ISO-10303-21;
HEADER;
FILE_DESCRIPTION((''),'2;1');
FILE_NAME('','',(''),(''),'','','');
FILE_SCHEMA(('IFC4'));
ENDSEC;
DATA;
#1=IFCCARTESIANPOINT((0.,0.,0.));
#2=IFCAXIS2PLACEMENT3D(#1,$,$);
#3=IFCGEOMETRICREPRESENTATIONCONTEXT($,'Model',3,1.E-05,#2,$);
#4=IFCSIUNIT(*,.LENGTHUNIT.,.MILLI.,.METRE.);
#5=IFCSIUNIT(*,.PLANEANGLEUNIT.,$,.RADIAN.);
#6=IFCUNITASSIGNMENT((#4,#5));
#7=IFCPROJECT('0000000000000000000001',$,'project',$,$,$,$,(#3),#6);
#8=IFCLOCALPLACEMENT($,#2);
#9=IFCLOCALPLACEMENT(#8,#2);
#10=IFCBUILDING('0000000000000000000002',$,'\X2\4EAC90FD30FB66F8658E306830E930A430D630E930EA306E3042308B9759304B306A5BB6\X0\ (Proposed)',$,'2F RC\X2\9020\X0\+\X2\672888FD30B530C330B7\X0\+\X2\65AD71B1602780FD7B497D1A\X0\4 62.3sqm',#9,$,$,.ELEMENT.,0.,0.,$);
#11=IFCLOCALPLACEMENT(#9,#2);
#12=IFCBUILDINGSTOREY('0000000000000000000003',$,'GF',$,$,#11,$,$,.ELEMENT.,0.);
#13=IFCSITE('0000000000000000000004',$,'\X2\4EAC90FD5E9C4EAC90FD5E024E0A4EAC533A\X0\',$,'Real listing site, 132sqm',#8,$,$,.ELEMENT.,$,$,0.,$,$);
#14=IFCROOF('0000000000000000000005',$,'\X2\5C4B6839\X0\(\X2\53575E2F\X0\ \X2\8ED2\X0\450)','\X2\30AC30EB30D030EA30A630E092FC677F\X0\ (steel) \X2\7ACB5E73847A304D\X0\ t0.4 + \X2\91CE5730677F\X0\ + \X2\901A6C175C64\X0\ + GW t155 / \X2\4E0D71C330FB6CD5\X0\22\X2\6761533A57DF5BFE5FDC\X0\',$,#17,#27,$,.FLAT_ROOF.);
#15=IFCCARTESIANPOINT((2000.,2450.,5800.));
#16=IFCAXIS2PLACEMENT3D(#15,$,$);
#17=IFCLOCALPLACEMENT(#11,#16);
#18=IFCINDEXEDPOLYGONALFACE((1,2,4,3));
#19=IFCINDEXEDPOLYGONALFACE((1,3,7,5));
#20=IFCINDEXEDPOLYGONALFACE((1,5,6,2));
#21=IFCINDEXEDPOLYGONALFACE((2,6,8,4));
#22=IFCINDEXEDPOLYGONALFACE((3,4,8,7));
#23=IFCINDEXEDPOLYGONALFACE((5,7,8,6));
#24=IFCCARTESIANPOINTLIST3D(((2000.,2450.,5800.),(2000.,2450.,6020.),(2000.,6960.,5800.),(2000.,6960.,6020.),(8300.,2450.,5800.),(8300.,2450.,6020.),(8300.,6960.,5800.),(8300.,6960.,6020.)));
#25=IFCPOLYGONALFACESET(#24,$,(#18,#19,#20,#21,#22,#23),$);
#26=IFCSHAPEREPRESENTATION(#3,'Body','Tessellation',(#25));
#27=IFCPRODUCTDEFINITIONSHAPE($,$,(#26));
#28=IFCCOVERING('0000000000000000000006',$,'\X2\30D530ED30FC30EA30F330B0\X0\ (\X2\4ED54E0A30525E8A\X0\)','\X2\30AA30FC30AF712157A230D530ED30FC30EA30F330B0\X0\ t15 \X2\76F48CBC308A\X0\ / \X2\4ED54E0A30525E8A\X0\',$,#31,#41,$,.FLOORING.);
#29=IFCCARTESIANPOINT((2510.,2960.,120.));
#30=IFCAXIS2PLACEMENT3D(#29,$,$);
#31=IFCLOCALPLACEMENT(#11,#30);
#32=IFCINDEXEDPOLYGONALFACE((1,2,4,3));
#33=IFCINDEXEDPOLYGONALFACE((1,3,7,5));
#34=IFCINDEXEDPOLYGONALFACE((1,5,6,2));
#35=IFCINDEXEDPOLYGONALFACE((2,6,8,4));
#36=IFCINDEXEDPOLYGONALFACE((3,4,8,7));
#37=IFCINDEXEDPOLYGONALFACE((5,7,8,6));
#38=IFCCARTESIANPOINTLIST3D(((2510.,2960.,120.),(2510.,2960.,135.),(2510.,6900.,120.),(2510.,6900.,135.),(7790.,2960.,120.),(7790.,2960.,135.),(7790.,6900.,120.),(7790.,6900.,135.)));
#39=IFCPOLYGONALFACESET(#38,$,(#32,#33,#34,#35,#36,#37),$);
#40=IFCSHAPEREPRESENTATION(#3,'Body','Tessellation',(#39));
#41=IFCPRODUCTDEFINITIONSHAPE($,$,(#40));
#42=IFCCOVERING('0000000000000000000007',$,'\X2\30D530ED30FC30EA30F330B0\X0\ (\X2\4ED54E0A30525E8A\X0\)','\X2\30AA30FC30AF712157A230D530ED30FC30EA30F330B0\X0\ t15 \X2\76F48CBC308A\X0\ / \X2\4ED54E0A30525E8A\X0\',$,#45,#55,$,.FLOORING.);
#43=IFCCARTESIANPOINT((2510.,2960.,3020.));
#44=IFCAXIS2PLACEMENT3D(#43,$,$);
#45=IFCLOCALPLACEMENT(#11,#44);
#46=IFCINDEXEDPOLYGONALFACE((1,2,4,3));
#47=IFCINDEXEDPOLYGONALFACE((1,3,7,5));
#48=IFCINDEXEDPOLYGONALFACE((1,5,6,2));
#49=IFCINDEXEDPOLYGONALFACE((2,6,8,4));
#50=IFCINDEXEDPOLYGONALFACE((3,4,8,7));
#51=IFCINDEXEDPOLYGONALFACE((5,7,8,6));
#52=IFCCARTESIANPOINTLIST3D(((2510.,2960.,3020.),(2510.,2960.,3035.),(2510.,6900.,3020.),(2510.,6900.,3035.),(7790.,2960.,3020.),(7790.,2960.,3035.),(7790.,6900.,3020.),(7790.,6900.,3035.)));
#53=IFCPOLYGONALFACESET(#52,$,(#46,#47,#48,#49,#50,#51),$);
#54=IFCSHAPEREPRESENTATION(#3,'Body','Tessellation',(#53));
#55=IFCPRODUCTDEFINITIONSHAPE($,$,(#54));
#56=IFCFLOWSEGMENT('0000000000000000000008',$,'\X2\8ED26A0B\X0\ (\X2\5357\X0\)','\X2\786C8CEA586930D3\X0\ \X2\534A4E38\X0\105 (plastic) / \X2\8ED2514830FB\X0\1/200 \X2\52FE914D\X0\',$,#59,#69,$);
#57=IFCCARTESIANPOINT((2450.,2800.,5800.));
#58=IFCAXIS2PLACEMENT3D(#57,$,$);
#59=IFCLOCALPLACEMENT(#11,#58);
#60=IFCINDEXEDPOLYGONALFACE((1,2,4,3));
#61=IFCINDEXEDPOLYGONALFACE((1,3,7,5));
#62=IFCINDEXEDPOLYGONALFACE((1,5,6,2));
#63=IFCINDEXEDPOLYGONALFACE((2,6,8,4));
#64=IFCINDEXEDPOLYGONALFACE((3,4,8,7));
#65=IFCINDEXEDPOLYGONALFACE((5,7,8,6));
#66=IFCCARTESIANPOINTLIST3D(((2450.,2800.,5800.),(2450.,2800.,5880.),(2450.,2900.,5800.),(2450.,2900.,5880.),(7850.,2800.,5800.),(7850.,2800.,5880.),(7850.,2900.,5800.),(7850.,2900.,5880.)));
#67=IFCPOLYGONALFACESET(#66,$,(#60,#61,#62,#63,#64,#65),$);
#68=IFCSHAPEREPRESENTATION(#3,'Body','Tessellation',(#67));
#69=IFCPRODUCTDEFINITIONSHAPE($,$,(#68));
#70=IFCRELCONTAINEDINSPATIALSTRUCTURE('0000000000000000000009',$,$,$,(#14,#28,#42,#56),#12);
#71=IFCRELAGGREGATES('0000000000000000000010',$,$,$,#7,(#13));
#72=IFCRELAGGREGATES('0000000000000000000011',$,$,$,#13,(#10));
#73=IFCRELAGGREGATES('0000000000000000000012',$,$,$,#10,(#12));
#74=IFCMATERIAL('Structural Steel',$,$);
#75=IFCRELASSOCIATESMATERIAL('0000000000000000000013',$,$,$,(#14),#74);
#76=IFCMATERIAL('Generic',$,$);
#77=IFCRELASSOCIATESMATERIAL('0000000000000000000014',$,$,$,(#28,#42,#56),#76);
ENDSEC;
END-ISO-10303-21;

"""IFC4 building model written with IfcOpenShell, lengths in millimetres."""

from ifc_helpers import new_model, si_unit, frame, frame_2d, origin, place, context, project, spatial, rectangle, extrude, material, element, save


model = new_model("IFC4")

# Units and contexts
model_context = context("Model", 3, precision=1e-05, world=origin())
ifc_project = project(units=[si_unit("LENGTHUNIT", "METRE", prefix="MILLI"), si_unit("PLANEANGLEUNIT", "RADIAN")], contexts=[model_context])

# Site, building, storey
site_placement = place(None, origin())
site = spatial("IfcSite", under=ifc_project, at=site_placement, Name="京都府京都市上京区", ObjectType="Real listing site, 132sqm", CompositionType="ELEMENT", RefElevation=0.0)
building_placement = place(site_placement, origin())
building = spatial("IfcBuilding", under=site, at=building_placement, Name="京都・書斎とライブラリのある静かな家 (Proposed)", ObjectType="2F RC造+木製サッシ+断熱性能等級4 62.3sqm", CompositionType="ELEMENT", ElevationOfRefHeight=0.0, ElevationOfTerrain=0.0)
storey_placement = place(building_placement, origin())
storey = spatial("IfcBuildingStorey", under=building, at=storey_placement, Name="GF", CompositionType="ELEMENT", Elevation=0.0)

# Roof
ifc_material_1 = material(Name="Structural Steel")
for number, where, name in (
    (1, (2000.0, 2450.0, 5800.0), "屋根(南帯 軒450)"),
):
    element("IfcRoof", number, at=place(storey_placement, frame(where)), inside=storey, material=ifc_material_1, Name=name, Description="ガルバリウム鋼板 (steel) 立平葺き t0.4 + 野地板 + 通気層 + GW t155 / 不燃・法22条区域対応", PredefinedType="FLAT_ROOF", context=model_context, shape_type="SweptSolid", body=[
        extrude(rectangle(XDim=6300.0, YDim=4510.0, at=frame_2d((3150.0, 2255.0))), frame((2000.0, 2450.0, 5800.0)), (0.0, 0.0, 1.0), 220.0),
    ])

# Coverings
ifc_material_2 = material(Name="Generic")
covering_1_placement = place(storey_placement, frame((2510.0, 2960.0, 120.0)))
element("IfcCovering", 2, at=covering_1_placement, inside=storey, material=ifc_material_2, Name="フローリング (仕上げ床)", Description="オーク無垢フローリング t15 直貼り / 仕上げ床", PredefinedType="FLOORING", context=model_context, shape_type="SweptSolid", body=[
    extrude(rectangle(XDim=5280.0, YDim=3940.0, at=frame_2d((2640.0, 1970.0))), frame((2510.0, 2960.0, 120.0)), (0.0, 0.0, 1.0), 15.0),
])
covering_2_placement = place(storey_placement, frame((2510.0, 2960.0, 3020.0)))
element("IfcCovering", 3, at=covering_2_placement, inside=storey, material=ifc_material_2, Name="フローリング (仕上げ床)", Description="オーク無垢フローリング t15 直貼り / 仕上げ床", PredefinedType="FLOORING", context=model_context, shape_type="SweptSolid", body=[
    extrude(rectangle(XDim=5280.0, YDim=3940.0, at=frame_2d((2640.0, 1970.0))), frame((2510.0, 2960.0, 3020.0)), (0.0, 0.0, 1.0), 15.0),
])

# Flow segment
flow_segment_placement = place(storey_placement, frame((2450.0, 2800.0, 5800.0)))
element("IfcFlowSegment", 4, at=flow_segment_placement, inside=storey, material=ifc_material_2, Name="軒樋 (南)", Description="硬質塩ビ 半丸105 (plastic) / 軒先・1/200 勾配", context=model_context, shape_type="SweptSolid", body=[
    extrude(rectangle(XDim=5400.0, YDim=100.0, at=frame_2d((2700.0, 50.0))), frame((2450.0, 2800.0, 5800.0)), (0.0, 0.0, 1.0), 80.0),
])

save(model, "model.ifc")
